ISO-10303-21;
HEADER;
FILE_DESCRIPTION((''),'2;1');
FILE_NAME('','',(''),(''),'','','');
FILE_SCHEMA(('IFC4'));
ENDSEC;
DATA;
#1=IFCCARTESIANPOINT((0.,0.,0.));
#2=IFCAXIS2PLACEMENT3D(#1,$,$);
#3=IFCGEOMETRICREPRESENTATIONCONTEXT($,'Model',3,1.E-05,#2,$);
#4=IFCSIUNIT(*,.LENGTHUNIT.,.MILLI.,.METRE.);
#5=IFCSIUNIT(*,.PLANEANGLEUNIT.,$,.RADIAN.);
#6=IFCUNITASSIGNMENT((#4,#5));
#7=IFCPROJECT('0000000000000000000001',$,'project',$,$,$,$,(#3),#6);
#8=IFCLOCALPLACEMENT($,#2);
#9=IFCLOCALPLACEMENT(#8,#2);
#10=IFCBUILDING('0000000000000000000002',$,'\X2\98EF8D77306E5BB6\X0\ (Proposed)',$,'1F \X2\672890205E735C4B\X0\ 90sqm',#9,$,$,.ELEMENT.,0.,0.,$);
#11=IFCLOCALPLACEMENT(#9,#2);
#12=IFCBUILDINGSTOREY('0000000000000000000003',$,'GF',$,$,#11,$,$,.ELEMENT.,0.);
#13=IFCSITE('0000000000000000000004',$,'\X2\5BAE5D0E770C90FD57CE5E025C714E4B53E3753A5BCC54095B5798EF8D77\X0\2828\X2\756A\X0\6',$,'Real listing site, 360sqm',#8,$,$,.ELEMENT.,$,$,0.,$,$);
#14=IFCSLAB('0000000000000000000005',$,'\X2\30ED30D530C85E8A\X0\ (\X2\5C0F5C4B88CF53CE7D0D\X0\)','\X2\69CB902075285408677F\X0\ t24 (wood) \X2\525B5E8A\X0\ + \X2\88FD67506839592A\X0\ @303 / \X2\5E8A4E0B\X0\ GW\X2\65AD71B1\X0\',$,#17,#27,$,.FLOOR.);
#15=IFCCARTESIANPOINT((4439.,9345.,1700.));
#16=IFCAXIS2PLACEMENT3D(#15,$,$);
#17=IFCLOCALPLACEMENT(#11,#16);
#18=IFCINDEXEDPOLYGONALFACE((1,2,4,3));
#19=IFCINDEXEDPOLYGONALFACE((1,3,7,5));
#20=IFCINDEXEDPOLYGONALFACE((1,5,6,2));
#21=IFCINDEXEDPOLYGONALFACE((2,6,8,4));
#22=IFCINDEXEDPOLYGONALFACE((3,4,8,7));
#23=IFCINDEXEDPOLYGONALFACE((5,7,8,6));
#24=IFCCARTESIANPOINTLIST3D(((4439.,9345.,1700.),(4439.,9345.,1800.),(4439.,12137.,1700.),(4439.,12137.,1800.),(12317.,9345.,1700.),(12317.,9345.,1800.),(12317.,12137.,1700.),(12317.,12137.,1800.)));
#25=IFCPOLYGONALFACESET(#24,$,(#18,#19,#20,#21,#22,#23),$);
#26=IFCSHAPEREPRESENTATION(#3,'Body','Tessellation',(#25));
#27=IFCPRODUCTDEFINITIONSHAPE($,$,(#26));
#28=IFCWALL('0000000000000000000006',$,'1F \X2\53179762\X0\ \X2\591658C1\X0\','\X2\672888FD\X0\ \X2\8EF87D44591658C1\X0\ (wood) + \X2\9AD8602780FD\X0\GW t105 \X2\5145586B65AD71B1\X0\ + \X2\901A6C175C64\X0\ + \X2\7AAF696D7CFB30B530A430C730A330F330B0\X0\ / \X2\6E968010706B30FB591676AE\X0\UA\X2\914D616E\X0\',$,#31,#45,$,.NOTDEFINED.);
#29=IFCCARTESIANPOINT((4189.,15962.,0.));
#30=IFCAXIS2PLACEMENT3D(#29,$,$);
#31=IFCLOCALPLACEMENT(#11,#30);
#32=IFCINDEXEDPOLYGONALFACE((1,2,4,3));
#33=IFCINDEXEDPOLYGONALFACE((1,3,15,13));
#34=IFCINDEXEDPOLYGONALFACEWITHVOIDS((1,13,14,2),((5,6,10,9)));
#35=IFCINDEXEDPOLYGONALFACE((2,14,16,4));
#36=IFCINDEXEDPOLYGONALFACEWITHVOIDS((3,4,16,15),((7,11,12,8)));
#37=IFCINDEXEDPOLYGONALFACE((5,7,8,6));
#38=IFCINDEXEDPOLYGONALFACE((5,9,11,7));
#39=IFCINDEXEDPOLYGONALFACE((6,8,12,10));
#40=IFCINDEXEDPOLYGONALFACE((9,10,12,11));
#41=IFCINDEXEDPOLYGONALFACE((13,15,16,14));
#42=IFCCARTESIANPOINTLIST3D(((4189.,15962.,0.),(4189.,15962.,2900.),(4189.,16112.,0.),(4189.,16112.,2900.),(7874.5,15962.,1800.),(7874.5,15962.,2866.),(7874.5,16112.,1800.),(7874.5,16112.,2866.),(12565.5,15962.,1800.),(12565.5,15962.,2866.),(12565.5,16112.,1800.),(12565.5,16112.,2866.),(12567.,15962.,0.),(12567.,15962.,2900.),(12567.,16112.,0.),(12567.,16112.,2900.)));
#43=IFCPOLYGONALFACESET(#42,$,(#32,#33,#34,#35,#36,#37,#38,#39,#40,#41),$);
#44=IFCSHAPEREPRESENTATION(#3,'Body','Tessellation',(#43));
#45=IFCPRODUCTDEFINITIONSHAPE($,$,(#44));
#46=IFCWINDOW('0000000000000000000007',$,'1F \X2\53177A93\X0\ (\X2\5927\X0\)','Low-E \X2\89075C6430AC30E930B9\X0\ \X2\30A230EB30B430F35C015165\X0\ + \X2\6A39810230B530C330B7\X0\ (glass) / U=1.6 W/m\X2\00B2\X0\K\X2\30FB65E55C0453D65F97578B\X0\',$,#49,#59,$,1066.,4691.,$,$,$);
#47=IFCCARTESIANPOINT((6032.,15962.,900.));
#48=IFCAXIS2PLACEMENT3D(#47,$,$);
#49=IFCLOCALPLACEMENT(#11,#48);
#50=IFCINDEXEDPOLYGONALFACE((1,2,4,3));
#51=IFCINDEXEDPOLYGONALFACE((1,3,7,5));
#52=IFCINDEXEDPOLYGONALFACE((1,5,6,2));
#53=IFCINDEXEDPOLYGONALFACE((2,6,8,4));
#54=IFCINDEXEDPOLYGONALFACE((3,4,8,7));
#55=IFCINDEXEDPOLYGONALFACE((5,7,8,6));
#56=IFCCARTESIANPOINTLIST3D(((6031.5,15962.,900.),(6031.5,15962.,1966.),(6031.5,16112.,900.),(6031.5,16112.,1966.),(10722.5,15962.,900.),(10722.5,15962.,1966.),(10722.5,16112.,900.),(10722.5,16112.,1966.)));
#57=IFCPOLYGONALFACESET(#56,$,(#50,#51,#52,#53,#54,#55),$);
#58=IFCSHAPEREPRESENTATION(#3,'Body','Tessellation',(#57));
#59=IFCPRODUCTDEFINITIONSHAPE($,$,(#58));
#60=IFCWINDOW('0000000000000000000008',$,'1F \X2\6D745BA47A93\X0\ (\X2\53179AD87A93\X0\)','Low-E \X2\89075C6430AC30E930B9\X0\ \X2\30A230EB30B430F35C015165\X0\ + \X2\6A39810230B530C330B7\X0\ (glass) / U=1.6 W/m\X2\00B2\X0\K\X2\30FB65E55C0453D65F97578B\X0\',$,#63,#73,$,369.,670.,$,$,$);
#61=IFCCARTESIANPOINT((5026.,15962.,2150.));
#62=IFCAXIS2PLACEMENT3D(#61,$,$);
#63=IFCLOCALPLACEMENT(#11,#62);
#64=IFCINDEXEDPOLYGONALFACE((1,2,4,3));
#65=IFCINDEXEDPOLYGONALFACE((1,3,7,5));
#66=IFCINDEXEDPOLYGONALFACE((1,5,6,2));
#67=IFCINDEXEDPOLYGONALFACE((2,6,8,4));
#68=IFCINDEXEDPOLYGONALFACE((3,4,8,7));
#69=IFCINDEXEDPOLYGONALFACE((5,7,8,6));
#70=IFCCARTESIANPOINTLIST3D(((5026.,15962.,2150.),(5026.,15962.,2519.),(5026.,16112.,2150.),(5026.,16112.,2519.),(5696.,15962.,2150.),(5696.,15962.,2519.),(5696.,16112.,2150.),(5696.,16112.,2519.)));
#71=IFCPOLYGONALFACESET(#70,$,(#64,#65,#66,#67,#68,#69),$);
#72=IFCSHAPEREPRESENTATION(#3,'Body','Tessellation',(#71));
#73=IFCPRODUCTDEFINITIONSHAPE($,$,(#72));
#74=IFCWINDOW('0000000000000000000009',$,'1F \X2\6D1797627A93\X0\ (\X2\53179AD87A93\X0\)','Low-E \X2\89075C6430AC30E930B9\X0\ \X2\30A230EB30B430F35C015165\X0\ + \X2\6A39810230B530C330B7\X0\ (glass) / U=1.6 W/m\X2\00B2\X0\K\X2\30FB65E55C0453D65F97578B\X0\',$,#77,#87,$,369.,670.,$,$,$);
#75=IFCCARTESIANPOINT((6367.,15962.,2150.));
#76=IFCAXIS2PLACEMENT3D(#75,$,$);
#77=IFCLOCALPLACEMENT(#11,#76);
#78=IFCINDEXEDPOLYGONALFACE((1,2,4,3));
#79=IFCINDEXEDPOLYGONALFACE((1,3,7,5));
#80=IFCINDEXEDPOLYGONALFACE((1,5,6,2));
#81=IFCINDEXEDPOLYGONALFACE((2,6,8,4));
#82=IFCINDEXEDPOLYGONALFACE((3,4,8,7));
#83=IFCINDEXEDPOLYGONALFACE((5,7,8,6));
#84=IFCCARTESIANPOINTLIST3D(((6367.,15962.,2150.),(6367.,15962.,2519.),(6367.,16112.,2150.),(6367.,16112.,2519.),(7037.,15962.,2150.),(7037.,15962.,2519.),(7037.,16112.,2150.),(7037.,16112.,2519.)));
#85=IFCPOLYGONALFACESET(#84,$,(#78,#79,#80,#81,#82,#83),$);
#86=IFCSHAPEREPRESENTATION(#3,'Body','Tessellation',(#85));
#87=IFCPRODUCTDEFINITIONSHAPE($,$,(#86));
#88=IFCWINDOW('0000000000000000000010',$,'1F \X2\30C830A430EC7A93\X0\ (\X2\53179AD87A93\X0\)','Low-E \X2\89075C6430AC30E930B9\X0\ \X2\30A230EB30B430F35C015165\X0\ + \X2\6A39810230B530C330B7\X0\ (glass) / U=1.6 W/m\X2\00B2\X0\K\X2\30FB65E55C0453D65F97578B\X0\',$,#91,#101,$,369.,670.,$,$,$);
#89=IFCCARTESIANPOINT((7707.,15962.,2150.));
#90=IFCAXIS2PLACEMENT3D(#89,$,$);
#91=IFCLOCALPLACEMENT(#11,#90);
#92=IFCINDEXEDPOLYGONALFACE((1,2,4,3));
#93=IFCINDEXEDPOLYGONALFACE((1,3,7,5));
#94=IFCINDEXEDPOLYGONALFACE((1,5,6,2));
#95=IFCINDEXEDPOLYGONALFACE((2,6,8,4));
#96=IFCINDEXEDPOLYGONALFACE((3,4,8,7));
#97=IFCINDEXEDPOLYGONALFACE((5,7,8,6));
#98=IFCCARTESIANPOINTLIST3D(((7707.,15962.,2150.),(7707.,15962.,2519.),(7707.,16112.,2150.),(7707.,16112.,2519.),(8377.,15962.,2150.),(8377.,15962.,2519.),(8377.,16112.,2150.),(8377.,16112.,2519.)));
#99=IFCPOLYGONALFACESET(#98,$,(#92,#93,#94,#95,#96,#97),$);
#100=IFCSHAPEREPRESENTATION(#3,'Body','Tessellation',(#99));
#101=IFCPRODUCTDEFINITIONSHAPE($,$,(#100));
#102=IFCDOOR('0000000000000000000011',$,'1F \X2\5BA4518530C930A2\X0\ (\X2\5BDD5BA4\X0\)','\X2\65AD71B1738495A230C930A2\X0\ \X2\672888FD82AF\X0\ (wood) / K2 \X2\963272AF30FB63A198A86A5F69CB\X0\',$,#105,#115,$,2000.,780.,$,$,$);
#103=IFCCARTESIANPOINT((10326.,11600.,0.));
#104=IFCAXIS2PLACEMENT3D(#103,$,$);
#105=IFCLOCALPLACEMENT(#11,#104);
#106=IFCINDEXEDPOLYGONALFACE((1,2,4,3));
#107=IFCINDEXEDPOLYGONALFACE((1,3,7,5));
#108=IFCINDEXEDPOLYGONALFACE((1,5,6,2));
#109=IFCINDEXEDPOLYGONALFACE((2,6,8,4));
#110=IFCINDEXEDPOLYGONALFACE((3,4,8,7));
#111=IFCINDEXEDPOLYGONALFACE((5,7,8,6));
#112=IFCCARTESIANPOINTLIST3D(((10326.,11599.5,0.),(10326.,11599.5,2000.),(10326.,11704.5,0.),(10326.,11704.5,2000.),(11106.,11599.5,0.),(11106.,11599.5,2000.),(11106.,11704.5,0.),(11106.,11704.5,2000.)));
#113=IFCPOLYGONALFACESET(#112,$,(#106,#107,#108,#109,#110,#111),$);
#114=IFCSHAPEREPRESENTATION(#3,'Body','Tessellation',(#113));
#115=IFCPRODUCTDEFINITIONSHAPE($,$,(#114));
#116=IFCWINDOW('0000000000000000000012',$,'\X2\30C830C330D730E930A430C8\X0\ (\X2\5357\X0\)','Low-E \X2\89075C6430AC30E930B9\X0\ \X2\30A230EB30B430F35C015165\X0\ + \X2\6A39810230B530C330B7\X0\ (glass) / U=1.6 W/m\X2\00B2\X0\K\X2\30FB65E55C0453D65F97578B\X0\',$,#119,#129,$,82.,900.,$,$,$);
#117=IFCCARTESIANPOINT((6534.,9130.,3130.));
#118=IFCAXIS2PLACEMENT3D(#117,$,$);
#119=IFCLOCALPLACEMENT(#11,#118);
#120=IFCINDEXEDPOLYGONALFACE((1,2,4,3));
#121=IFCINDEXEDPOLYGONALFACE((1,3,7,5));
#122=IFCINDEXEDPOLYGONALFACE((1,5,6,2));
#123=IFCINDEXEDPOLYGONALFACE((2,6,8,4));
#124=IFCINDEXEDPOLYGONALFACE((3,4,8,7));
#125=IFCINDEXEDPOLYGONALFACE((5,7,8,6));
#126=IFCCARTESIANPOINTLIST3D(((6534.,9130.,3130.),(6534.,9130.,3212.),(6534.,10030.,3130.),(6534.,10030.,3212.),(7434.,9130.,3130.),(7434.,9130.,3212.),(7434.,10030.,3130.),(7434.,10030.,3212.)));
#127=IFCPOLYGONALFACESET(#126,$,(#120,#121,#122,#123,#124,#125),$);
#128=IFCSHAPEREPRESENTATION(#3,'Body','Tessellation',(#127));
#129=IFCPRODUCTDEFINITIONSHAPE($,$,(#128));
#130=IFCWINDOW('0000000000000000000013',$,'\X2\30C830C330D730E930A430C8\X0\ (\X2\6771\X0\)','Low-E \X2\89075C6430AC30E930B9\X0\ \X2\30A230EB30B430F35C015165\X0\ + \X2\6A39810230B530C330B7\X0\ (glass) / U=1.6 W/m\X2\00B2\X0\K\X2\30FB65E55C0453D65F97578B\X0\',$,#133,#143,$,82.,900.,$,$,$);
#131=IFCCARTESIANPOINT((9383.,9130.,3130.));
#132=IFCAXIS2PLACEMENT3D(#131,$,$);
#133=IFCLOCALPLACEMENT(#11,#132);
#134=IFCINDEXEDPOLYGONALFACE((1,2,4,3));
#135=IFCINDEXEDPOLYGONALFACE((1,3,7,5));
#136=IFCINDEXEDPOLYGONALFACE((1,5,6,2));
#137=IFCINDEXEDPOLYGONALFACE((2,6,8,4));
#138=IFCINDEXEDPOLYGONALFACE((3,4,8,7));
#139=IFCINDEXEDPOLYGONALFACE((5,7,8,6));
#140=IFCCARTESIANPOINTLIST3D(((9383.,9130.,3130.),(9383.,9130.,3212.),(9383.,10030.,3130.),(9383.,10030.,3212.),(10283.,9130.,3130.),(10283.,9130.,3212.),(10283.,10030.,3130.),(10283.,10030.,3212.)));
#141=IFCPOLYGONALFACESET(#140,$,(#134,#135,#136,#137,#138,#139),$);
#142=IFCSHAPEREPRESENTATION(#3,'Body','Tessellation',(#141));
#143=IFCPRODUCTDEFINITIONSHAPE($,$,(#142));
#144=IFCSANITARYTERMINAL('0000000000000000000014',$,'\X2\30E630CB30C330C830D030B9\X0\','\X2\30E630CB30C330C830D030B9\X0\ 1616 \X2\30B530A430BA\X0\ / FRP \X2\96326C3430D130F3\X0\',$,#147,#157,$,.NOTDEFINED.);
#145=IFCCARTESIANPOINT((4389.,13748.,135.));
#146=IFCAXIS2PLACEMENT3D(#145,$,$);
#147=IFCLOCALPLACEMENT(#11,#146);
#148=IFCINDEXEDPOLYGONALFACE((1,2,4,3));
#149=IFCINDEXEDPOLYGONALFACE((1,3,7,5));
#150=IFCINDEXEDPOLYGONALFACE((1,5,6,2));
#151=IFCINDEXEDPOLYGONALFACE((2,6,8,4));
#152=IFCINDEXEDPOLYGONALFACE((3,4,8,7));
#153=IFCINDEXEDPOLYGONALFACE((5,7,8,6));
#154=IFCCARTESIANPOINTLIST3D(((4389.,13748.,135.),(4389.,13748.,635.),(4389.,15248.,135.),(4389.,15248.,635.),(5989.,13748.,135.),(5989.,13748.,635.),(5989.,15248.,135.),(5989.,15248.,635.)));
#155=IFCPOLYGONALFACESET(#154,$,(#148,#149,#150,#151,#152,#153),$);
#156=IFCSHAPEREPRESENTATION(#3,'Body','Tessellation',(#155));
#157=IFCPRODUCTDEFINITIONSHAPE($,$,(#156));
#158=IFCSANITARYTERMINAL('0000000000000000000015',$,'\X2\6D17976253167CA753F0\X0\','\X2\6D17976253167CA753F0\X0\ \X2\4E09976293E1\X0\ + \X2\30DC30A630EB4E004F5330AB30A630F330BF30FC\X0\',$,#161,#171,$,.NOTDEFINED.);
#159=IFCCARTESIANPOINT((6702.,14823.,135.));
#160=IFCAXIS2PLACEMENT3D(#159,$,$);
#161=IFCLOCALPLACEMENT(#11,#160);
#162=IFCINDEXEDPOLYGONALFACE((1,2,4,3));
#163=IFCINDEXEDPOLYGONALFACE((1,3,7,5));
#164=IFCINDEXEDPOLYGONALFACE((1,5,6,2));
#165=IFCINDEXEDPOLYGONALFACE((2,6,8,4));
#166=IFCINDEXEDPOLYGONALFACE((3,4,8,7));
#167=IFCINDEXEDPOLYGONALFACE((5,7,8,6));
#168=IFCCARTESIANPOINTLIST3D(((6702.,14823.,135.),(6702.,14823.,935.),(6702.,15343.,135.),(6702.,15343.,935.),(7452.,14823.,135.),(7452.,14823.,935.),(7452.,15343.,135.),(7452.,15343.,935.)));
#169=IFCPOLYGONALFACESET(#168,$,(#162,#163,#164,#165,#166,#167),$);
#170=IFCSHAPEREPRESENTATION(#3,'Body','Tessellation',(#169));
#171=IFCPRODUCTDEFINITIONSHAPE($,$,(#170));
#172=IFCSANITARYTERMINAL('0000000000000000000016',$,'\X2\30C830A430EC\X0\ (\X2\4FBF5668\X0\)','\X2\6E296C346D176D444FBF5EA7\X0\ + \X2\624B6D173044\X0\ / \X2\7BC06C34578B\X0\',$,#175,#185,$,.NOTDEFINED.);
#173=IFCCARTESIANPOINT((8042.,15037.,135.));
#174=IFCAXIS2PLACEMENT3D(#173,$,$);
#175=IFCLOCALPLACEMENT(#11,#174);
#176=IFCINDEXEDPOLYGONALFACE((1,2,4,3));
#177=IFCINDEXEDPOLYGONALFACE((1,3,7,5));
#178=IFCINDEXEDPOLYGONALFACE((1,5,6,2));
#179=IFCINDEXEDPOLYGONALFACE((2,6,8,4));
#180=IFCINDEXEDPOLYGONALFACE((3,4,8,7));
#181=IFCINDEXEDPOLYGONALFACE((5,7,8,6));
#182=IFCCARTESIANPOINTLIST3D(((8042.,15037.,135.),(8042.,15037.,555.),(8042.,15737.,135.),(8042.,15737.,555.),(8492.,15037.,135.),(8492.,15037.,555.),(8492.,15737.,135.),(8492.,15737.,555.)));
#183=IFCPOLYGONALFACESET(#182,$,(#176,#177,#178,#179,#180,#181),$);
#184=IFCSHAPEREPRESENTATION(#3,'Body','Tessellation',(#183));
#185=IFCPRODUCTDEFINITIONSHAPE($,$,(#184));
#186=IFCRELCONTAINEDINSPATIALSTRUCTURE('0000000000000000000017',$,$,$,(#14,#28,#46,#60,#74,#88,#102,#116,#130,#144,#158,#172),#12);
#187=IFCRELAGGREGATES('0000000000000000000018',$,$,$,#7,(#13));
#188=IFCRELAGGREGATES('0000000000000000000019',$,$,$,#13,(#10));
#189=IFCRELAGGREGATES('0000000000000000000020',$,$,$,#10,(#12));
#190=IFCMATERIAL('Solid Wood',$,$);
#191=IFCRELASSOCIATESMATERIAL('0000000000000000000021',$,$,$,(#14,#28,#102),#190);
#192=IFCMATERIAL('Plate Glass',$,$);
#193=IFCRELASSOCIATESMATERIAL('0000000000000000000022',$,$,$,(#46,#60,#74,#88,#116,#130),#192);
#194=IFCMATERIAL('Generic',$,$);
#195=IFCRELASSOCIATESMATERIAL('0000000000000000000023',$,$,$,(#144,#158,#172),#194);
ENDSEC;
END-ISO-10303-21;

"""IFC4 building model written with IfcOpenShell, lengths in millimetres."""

from ifc_helpers import new_model, si_unit, frame, frame_2d, origin, place, context, project, spatial, rectangle, extrude, material, element, fill, save


model = new_model("IFC4")

# Units and contexts
model_context = context("Model", 3, precision=1e-05, world=origin())
ifc_project = project(units=[si_unit("LENGTHUNIT", "METRE", prefix="MILLI"), si_unit("PLANEANGLEUNIT", "RADIAN")], contexts=[model_context])

# Site, building, storey
site_placement = place(None, origin())
site = spatial("IfcSite", under=ifc_project, at=site_placement, Name="宮崎県都城市山之口町富吉字飯起2828番6", ObjectType="Real listing site, 360sqm", CompositionType="ELEMENT", RefElevation=0.0)
building_placement = place(site_placement, origin())
building = spatial("IfcBuilding", under=site, at=building_placement, Name="飯起の家 (Proposed)", ObjectType="1F 木造平屋 90sqm", CompositionType="ELEMENT", ElevationOfRefHeight=0.0, ElevationOfTerrain=0.0)
storey_placement = place(building_placement, origin())
storey = spatial("IfcBuildingStorey", under=building, at=storey_placement, Name="GF", CompositionType="ELEMENT", Elevation=0.0)

# Slab
ifc_material_1 = material(Name="Solid Wood")
slab_placement = place(storey_placement, frame((4439.0, 9345.0, 1700.0)))
element("IfcSlab", 1, at=slab_placement, inside=storey, material=ifc_material_1, Name="ロフト床 (小屋裏収納)", Description="構造用合板 t24 (wood) 剛床 + 製材根太 @303 / 床下 GW断熱", PredefinedType="FLOOR", context=model_context, shape_type="SweptSolid", body=[
    extrude(rectangle(XDim=7878.0, YDim=2792.0, at=frame_2d((3939.0, 1396.0))), frame((4439.0, 9345.0, 1700.0)), (0.0, 0.0, 1.0), 100.0),
])

# Wall, openings, windows
wall_1_placement = place(storey_placement, frame((4189.0, 15962.0, 0.0)))
wall_1 = element("IfcWall", 2, at=wall_1_placement, inside=storey, material=ifc_material_1, Name="1F 北面 外壁", Description="木製 軸組外壁 (wood) + 高性能GW t105 充填断熱 + 通気層 + 窯業系サイディング / 準耐火・外皮UA配慮", PredefinedType="NOTDEFINED", context=model_context, shape_type="SweptSolid", body=[
    extrude(rectangle(XDim=8378.0, YDim=150.0, at=frame_2d((4189.0, 75.0))), frame((4189.0, 15962.0, 0.0)), (0.0, 0.0, 1.0), 2900.0),
])
opening_1_placement = place(storey_placement, frame((6032.0, 15962.0, 900.0)))
opening_1 = element("IfcOpeningElement", 3, at=opening_1_placement, cuts=wall_1, PredefinedType="NOTDEFINED", context=model_context, shape_type="SweptSolid", body=[
    extrude(rectangle(XDim=4691.0, YDim=150.0, at=frame_2d((2345.0, 75.0))), frame((6032.0, 15962.0, 900.0)), (0.0, 0.0, 1.0), 1066.0),
])
opening_2_placement = place(storey_placement, frame((5026.0, 15962.0, 2150.0)))
opening_2 = element("IfcOpeningElement", 4, at=opening_2_placement, cuts=wall_1, PredefinedType="NOTDEFINED", context=model_context, shape_type="SweptSolid", body=[
    extrude(rectangle(XDim=670.0, YDim=150.0, at=frame_2d((335.0, 75.0))), frame((5026.0, 15962.0, 2150.0)), (0.0, 0.0, 1.0), 369.0),
])
opening_3_placement = place(storey_placement, frame((6367.0, 15962.0, 2150.0)))
opening_3 = element("IfcOpeningElement", 5, at=opening_3_placement, cuts=wall_1, PredefinedType="NOTDEFINED", context=model_context, shape_type="SweptSolid", body=[
    extrude(rectangle(XDim=670.0, YDim=150.0, at=frame_2d((335.0, 75.0))), frame((6367.0, 15962.0, 2150.0)), (0.0, 0.0, 1.0), 369.0),
])
opening_4_placement = place(storey_placement, frame((7707.0, 15962.0, 2150.0)))
opening_4 = element("IfcOpeningElement", 6, at=opening_4_placement, cuts=wall_1, PredefinedType="NOTDEFINED", context=model_context, shape_type="SweptSolid", body=[
    extrude(rectangle(XDim=670.0, YDim=150.0, at=frame_2d((335.0, 75.0))), frame((7707.0, 15962.0, 2150.0)), (0.0, 0.0, 1.0), 369.0),
])
ifc_material_2 = material(Name="Plate Glass")
window_1_placement = place(storey_placement, frame((6032.0, 15962.0, 900.0)))
window_1 = element("IfcWindow", 7, at=window_1_placement, inside=storey, material=ifc_material_2, Name="1F 北窓 (大)", Description="Low-E 複層ガラス アルゴン封入 + 樹脂サッシ (glass) / U=1.6 W/m²K・日射取得型", OverallHeight=1066.0, OverallWidth=4691.0, context=model_context, shape_type="SweptSolid", body=[
    extrude(rectangle(XDim=4691.0, YDim=150.0, at=frame_2d((2345.0, 75.0))), frame((6032.0, 15962.0, 900.0)), (0.0, 0.0, 1.0), 1066.0),
])
fill(opening_1, window_1)
window_2_placement = place(storey_placement, frame((5026.0, 15962.0, 2150.0)))
window_2 = element("IfcWindow", 8, at=window_2_placement, inside=storey, material=ifc_material_2, Name="1F 浴室窓 (北高窓)", Description="Low-E 複層ガラス アルゴン封入 + 樹脂サッシ (glass) / U=1.6 W/m²K・日射取得型", OverallHeight=369.0, OverallWidth=670.0, context=model_context, shape_type="SweptSolid", body=[
    extrude(rectangle(XDim=670.0, YDim=150.0, at=frame_2d((335.0, 75.0))), frame((5026.0, 15962.0, 2150.0)), (0.0, 0.0, 1.0), 369.0),
])
fill(opening_2, window_2)
window_3_placement = place(storey_placement, frame((6367.0, 15962.0, 2150.0)))
window_3 = element("IfcWindow", 9, at=window_3_placement, inside=storey, material=ifc_material_2, Name="1F 洗面窓 (北高窓)", Description="Low-E 複層ガラス アルゴン封入 + 樹脂サッシ (glass) / U=1.6 W/m²K・日射取得型", OverallHeight=369.0, OverallWidth=670.0, context=model_context, shape_type="SweptSolid", body=[
    extrude(rectangle(XDim=670.0, YDim=150.0, at=frame_2d((335.0, 75.0))), frame((6367.0, 15962.0, 2150.0)), (0.0, 0.0, 1.0), 369.0),
])
fill(opening_3, window_3)
window_4_placement = place(storey_placement, frame((7707.0, 15962.0, 2150.0)))
window_4 = element("IfcWindow", 10, at=window_4_placement, inside=storey, material=ifc_material_2, Name="1F トイレ窓 (北高窓)", Description="Low-E 複層ガラス アルゴン封入 + 樹脂サッシ (glass) / U=1.6 W/m²K・日射取得型", OverallHeight=369.0, OverallWidth=670.0, context=model_context, shape_type="SweptSolid", body=[
    extrude(rectangle(XDim=670.0, YDim=150.0, at=frame_2d((335.0, 75.0))), frame((7707.0, 15962.0, 2150.0)), (0.0, 0.0, 1.0), 369.0),
])
fill(opening_4, window_4)

# Door
door_1_placement = place(storey_placement, frame((10326.0, 11600.0, 0.0)))
element("IfcDoor", 11, at=door_1_placement, inside=storey, material=ifc_material_1, Name="1F 室内ドア (寝室)", Description="断熱玄関ドア 木製芯 (wood) / K2 防犯・採風機構", OverallHeight=2000.0, OverallWidth=780.0, context=model_context, shape_type="SweptSolid", body=[
    extrude(rectangle(XDim=780.0, YDim=105.0, at=frame_2d((390.0, 52.0))), frame((10326.0, 11600.0, 0.0)), (0.0, 0.0, 1.0), 2000.0),
])

# Windows
window_5_placement = place(storey_placement, frame((6534.0, 9130.0, 3130.0)))
element("IfcWindow", 12, at=window_5_placement, inside=storey, material=ifc_material_2, Name="トップライト (南)", Description="Low-E 複層ガラス アルゴン封入 + 樹脂サッシ (glass) / U=1.6 W/m²K・日射取得型", OverallHeight=82.0, OverallWidth=900.0, context=model_context, shape_type="SweptSolid", body=[
    extrude(rectangle(XDim=900.0, YDim=900.0, at=frame_2d((450.0, 450.0))), frame((6534.0, 9130.0, 3130.0)), (0.0, 0.0, 1.0), 82.0),
])
window_6_placement = place(storey_placement, frame((9383.0, 9130.0, 3130.0)))
element("IfcWindow", 13, at=window_6_placement, inside=storey, material=ifc_material_2, Name="トップライト (東)", Description="Low-E 複層ガラス アルゴン封入 + 樹脂サッシ (glass) / U=1.6 W/m²K・日射取得型", OverallHeight=82.0, OverallWidth=900.0, context=model_context, shape_type="SweptSolid", body=[
    extrude(rectangle(XDim=900.0, YDim=900.0, at=frame_2d((450.0, 450.0))), frame((9383.0, 9130.0, 3130.0)), (0.0, 0.0, 1.0), 82.0),
])

# Sanitary terminals
ifc_material_3 = material(Name="Generic")
sanitary_terminal_1_placement = place(storey_placement, frame((4389.0, 13748.0, 135.0)))
element("IfcSanitaryTerminal", 14, at=sanitary_terminal_1_placement, inside=storey, material=ifc_material_3, Name="ユニットバス", Description="ユニットバス 1616 サイズ / FRP 防水パン", PredefinedType="NOTDEFINED", context=model_context, shape_type="SweptSolid", body=[
    extrude(rectangle(XDim=1600.0, YDim=1500.0, at=frame_2d((800.0, 750.0))), frame((4389.0, 13748.0, 135.0)), (0.0, 0.0, 1.0), 500.0),
])
sanitary_terminal_2_placement = place(storey_placement, frame((6702.0, 14823.0, 135.0)))
element("IfcSanitaryTerminal", 15, at=sanitary_terminal_2_placement, inside=storey, material=ifc_material_3, Name="洗面化粧台", Description="洗面化粧台 三面鏡 + ボウル一体カウンター", PredefinedType="NOTDEFINED", context=model_context, shape_type="SweptSolid", body=[
    extrude(rectangle(XDim=750.0, YDim=520.0, at=frame_2d((375.0, 260.0))), frame((6702.0, 14823.0, 135.0)), (0.0, 0.0, 1.0), 800.0),
])
sanitary_terminal_3_placement = place(storey_placement, frame((8042.0, 15037.0, 135.0)))
element("IfcSanitaryTerminal", 16, at=sanitary_terminal_3_placement, inside=storey, material=ifc_material_3, Name="トイレ (便器)", Description="温水洗浄便座 + 手洗い / 節水型", PredefinedType="NOTDEFINED", context=model_context, shape_type="SweptSolid", body=[
    extrude(rectangle(XDim=450.0, YDim=700.0, at=frame_2d((225.0, 350.0))), frame((8042.0, 15037.0, 135.0)), (0.0, 0.0, 1.0), 420.0),
])

save(model, "model.ifc")
